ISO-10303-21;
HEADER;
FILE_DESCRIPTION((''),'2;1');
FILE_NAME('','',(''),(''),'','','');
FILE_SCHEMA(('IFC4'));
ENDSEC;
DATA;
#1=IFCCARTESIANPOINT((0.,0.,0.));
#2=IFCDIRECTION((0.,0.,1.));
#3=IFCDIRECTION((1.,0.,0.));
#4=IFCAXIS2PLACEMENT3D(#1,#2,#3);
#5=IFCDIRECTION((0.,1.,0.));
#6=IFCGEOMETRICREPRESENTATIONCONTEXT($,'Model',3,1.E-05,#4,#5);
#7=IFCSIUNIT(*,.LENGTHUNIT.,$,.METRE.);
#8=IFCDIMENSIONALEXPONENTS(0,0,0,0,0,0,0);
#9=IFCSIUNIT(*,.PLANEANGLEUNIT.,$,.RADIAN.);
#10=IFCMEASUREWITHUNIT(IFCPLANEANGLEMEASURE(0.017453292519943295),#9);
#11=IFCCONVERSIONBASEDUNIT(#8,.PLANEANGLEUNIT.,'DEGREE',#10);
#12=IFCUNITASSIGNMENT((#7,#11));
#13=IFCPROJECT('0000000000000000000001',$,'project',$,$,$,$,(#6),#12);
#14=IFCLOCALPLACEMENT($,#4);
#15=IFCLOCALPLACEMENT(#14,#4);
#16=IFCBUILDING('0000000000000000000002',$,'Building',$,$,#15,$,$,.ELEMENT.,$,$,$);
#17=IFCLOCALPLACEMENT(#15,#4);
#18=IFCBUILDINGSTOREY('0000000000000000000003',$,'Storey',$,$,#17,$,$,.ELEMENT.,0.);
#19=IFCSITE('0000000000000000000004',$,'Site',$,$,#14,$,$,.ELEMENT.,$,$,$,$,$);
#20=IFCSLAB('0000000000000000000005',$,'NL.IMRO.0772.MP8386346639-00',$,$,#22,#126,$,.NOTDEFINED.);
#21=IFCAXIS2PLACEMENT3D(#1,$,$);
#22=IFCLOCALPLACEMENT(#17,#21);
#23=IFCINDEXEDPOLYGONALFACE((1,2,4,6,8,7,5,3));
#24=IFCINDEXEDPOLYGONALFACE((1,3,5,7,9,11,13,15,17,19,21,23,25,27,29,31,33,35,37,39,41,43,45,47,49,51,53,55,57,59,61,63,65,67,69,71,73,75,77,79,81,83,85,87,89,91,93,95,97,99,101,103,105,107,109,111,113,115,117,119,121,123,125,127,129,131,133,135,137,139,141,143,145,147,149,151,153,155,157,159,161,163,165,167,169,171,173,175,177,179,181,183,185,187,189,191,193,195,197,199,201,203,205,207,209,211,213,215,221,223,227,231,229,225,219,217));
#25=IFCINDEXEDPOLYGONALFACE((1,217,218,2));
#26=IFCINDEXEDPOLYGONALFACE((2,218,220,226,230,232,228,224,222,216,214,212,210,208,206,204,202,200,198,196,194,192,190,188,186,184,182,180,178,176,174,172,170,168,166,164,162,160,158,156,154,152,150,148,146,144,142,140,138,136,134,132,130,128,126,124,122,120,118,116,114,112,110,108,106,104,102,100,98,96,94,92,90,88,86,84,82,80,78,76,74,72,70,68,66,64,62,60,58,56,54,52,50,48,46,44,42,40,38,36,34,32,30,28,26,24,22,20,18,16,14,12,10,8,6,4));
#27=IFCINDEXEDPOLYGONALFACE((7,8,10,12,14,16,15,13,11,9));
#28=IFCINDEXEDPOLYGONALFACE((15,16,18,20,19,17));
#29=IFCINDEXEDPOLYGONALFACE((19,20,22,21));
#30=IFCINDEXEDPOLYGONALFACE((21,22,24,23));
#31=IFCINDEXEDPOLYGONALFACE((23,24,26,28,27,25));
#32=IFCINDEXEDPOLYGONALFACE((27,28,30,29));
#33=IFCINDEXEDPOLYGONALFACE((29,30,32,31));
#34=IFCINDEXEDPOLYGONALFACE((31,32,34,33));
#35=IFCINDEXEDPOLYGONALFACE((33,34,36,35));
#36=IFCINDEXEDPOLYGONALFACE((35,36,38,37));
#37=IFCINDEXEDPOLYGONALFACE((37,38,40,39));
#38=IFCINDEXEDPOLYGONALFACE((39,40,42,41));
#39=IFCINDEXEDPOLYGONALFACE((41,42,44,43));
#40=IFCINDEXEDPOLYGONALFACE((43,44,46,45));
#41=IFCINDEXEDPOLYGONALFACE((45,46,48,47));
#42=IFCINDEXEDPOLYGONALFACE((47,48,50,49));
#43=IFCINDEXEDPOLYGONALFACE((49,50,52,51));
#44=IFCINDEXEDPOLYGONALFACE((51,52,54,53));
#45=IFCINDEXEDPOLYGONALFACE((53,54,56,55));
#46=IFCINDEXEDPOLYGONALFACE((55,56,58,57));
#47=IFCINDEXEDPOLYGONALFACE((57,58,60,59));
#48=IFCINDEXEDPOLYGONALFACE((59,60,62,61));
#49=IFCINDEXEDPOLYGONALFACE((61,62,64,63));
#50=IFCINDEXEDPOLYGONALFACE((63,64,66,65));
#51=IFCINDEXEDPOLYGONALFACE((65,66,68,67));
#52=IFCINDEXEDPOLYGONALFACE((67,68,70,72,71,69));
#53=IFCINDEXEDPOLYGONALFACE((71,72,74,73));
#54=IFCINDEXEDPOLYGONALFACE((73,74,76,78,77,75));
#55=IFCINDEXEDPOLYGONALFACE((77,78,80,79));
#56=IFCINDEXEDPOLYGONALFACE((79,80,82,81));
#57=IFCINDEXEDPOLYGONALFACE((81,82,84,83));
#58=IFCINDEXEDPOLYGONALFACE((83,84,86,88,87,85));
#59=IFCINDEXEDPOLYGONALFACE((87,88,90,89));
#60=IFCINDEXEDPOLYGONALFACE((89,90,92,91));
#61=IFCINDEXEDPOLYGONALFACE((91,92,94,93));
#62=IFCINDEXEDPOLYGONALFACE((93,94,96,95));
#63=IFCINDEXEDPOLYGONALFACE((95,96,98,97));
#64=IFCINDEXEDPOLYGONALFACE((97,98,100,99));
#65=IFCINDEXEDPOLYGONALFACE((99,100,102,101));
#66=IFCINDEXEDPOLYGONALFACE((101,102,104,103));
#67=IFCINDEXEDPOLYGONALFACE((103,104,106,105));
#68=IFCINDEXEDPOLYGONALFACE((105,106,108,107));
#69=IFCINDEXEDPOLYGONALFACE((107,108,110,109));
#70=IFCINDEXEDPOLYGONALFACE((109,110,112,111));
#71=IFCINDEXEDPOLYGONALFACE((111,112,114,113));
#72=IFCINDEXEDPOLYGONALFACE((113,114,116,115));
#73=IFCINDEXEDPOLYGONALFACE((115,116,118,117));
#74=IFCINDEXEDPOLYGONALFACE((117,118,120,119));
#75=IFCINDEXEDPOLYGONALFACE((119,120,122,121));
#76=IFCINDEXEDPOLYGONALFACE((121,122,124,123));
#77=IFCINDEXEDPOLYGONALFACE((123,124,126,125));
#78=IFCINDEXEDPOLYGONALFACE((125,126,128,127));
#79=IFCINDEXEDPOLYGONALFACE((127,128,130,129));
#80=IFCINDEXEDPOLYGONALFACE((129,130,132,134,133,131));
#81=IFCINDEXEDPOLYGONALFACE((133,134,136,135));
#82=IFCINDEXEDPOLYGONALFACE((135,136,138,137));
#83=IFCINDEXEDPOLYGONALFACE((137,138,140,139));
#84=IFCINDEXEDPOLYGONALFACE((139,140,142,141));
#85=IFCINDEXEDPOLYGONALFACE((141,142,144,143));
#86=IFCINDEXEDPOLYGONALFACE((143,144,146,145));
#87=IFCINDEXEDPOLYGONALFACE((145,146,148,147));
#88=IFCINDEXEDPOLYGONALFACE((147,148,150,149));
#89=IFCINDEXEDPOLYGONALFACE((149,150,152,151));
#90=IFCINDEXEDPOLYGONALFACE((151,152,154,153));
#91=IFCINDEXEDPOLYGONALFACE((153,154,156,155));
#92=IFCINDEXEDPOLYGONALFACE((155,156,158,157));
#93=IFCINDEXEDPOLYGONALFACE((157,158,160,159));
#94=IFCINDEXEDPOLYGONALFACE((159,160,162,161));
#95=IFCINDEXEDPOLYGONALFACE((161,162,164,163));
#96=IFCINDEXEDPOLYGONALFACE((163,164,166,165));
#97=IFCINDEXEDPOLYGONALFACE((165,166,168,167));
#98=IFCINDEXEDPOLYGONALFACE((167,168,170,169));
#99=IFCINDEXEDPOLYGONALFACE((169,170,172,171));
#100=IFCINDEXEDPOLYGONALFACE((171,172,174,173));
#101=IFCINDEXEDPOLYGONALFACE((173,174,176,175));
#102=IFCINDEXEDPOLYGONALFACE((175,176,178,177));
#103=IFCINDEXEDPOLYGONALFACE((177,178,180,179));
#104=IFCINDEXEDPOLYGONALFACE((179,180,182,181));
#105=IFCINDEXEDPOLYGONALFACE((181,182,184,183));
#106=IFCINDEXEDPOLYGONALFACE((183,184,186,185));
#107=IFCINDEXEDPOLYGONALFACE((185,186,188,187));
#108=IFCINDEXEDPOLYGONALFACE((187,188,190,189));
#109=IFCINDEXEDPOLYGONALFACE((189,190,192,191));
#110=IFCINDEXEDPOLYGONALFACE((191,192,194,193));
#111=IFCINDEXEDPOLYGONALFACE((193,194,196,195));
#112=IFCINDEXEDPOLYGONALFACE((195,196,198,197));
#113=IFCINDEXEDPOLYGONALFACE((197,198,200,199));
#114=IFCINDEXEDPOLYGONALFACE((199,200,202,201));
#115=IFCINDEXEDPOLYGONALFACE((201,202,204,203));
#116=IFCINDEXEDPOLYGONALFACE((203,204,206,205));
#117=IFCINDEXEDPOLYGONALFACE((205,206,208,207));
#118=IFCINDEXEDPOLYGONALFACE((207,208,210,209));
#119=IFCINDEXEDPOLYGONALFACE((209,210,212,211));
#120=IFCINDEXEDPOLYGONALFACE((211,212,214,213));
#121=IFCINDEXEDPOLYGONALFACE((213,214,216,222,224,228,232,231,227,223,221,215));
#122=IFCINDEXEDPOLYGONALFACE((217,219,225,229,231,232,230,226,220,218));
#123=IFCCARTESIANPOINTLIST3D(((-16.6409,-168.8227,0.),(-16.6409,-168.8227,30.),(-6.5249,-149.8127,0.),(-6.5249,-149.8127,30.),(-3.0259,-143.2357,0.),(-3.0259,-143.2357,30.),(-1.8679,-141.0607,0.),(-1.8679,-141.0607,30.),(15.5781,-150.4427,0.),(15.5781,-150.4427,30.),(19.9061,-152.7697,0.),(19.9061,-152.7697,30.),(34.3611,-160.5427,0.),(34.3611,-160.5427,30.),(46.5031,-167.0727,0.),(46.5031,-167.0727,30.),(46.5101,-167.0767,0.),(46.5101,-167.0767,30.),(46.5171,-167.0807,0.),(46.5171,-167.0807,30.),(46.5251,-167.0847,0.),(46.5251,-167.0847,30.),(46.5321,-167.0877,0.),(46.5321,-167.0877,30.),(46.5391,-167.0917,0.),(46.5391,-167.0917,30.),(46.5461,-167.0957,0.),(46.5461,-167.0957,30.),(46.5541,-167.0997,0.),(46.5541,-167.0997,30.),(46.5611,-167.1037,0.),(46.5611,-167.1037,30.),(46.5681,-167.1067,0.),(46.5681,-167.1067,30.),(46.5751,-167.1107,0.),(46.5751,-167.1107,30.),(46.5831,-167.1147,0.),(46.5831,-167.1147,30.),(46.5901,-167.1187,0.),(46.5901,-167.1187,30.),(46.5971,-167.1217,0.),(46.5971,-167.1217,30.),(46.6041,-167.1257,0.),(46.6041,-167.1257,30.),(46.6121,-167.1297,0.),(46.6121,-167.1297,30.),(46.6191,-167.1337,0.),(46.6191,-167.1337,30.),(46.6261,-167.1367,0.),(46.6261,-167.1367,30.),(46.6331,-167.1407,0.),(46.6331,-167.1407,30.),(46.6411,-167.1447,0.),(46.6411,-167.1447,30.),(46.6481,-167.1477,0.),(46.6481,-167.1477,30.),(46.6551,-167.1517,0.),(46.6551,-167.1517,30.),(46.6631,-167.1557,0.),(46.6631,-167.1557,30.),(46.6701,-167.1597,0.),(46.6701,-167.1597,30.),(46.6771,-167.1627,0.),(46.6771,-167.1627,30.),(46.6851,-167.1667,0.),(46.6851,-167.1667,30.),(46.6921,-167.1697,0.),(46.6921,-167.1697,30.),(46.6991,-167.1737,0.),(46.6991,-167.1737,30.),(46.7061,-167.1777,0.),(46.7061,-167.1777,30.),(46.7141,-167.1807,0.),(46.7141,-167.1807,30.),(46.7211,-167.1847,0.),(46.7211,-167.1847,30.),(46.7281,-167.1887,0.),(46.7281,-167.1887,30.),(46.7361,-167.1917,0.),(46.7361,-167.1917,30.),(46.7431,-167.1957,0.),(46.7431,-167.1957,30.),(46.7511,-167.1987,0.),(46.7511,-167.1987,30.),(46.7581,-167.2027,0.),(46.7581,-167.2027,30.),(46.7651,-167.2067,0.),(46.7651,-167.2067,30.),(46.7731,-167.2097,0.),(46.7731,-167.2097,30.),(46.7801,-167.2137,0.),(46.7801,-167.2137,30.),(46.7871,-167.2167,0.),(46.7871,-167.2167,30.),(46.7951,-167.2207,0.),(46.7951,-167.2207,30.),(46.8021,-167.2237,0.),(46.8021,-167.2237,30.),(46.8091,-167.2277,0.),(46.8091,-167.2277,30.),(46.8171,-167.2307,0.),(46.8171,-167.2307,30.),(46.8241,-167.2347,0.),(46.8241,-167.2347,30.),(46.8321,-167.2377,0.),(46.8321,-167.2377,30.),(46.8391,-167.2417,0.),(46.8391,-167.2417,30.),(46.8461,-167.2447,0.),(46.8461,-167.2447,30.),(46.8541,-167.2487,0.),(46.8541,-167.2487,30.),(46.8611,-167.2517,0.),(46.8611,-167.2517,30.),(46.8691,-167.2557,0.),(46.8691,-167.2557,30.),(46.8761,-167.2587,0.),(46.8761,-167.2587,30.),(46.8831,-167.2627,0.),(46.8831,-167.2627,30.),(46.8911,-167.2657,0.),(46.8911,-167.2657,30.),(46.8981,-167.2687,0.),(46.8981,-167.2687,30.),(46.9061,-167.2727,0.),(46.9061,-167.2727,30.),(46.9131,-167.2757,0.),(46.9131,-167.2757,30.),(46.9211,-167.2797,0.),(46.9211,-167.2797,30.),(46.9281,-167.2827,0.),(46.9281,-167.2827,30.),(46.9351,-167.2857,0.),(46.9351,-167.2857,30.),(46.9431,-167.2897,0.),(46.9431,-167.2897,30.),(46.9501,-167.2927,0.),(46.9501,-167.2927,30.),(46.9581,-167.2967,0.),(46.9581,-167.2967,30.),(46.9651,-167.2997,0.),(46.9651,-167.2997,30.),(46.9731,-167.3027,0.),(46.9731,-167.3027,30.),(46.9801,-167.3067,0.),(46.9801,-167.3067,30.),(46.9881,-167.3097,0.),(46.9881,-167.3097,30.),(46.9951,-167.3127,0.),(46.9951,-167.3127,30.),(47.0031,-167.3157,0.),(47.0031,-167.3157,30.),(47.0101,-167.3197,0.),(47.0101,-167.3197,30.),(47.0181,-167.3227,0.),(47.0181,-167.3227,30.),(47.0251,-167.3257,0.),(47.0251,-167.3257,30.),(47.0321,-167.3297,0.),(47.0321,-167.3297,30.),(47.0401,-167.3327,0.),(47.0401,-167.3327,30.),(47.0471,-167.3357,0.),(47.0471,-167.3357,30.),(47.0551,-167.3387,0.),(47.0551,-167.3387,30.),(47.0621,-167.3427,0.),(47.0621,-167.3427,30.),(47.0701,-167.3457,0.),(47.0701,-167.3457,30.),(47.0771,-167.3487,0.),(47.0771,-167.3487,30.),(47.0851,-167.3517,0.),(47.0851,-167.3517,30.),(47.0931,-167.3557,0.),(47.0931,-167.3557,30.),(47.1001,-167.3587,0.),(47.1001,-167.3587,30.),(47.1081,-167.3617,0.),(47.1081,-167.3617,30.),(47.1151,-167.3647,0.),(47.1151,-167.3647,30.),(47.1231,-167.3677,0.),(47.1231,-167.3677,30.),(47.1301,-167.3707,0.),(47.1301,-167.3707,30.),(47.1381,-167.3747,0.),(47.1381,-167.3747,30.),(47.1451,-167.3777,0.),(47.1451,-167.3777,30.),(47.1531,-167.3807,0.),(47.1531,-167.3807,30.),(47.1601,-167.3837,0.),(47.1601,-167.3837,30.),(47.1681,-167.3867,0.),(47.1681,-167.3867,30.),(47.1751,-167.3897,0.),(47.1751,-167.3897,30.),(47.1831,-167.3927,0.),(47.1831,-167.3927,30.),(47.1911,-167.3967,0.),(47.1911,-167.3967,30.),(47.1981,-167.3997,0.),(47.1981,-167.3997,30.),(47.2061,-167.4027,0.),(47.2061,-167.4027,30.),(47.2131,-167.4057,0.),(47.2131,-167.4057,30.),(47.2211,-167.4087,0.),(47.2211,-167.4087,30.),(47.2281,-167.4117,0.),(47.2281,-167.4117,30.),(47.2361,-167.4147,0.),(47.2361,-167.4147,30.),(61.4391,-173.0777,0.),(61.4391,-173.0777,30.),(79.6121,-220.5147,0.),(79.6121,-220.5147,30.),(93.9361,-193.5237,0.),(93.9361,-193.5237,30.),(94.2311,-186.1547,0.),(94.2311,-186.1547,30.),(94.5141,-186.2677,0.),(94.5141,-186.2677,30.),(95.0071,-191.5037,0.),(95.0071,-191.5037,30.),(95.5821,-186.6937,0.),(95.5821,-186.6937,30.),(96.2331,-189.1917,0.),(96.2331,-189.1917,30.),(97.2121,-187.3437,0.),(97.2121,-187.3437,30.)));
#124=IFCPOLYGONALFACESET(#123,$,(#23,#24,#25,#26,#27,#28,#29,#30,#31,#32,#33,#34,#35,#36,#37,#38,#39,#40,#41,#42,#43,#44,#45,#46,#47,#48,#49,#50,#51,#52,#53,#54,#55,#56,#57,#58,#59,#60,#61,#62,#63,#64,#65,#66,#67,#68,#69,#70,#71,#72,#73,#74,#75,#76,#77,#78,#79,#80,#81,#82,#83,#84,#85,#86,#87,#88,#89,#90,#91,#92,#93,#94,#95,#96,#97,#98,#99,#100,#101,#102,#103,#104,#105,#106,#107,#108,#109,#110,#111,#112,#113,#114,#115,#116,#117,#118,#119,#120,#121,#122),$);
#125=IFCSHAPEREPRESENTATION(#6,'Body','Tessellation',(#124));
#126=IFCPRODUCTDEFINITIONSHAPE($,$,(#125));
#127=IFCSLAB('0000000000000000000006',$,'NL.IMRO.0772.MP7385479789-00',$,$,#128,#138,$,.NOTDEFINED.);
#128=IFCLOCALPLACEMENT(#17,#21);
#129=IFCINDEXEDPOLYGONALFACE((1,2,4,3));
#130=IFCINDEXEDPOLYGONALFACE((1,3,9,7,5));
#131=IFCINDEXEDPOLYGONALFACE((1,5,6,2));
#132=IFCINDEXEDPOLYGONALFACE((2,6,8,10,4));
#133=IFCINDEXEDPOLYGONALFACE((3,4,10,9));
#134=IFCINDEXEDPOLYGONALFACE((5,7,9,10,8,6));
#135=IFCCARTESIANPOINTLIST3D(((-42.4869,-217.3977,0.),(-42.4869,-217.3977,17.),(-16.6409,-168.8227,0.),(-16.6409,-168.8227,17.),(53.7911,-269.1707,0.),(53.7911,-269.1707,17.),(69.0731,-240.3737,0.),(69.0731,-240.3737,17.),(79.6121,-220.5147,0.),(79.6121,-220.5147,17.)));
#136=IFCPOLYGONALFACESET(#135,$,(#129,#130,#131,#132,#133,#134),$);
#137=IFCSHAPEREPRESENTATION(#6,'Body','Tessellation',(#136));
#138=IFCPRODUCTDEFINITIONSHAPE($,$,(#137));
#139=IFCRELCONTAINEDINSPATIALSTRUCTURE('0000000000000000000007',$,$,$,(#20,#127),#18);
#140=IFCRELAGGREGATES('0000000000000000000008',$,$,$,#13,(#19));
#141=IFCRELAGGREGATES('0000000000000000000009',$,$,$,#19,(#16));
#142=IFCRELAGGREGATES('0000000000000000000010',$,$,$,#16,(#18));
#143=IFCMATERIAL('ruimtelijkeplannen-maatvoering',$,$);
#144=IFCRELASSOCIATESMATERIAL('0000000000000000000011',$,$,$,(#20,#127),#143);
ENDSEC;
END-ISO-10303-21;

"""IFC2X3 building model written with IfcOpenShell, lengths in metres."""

from ifc_helpers import new_model, entity, si_unit, converted_unit, direction, origin_with_axes, place, context, project, spatial, polyline, outline, extrude, material, element, save


model = new_model("IFC2X3")

# Units and contexts
model_context = context("Model", 3, precision=1e-05, world=origin_with_axes(), true_north=direction((0.0, 1.0, 0.0)))
ifc_project = project(units=[si_unit("LENGTHUNIT", "METRE"), converted_unit("PLANEANGLEUNIT", "DEGREE", entity("IfcPlaneAngleMeasure", 0.017453292519943295), si_unit("PLANEANGLEUNIT", "RADIAN"), dimensions=[0, 0, 0, 0, 0, 0, 0])], contexts=[model_context])

# Site, building, storey
site_placement = place(None, origin_with_axes())
site = spatial("IfcSite", under=ifc_project, at=site_placement, Name="Site", CompositionType="ELEMENT")
building_placement = place(site_placement, origin_with_axes())
building = spatial("IfcBuilding", under=site, at=building_placement, Name="Building", CompositionType="ELEMENT")
storey_placement = place(building_placement, origin_with_axes())
storey = spatial("IfcBuildingStorey", under=building, at=storey_placement, Name="Storey", CompositionType="ELEMENT", Elevation=0.0)

# Slabs
ifc_material = material(Name="ruimtelijkeplannen-maatvoering")
slab_1_placement = place(storey_placement, origin_with_axes())
element("IfcSlab", 1, at=slab_1_placement, inside=storey, material=ifc_material, Name="NL.IMRO.0772.MP8386346639-00", PredefinedType="NOTDEFINED", context=model_context, shape_type="SweptSolid", body=[
    extrude(outline(polyline([(46.5101, -167.0767), (46.5171, -167.0807), (46.5251, -167.0847), (46.5321, -167.0877), (46.5391, -167.0917), (46.5461, -167.0957), (46.5541, -167.0997), (46.5611, -167.1037), (46.5681, -167.1067), (46.5751, -167.1107), (46.5831, -167.1147), (46.5901, -167.1187), (46.5971, -167.1217), (46.6041, -167.1257), (46.6121, -167.1297), (46.6191, -167.1337), (46.6261, -167.1367), (46.6331, -167.1407), (46.6411, -167.1447), (46.6481, -167.1477), (46.6551, -167.1517), (46.6631, -167.1557), (46.6701, -167.1597), (46.6771, -167.1627), (46.6851, -167.1667), (46.6921, -167.1697), (46.6991, -167.1737), (46.7061, -167.1777), (46.7141, -167.1807), (46.7211, -167.1847), (46.7281, -167.1887), (46.7361, -167.1917), (46.7431, -167.1957), (46.7511, -167.1987), (46.7581, -167.2027), (46.7651, -167.2067), (46.7731, -167.2097), (46.7801, -167.2137), (46.7871, -167.2167), (46.7951, -167.2207), (46.8021, -167.2237), (46.8091, -167.2277), (46.8171, -167.2307), (46.8241, -167.2347), (46.8321, -167.2377), (46.8391, -167.2417), (46.8461, -167.2447), (46.8541, -167.2487), (46.8611, -167.2517), (46.8691, -167.2557), (46.8761, -167.2587), (46.8831, -167.2627), (46.8911, -167.2657), (46.8981, -167.2687), (46.9061, -167.2727), (46.9131, -167.2757), (46.9211, -167.2797), (46.9281, -167.2827), (46.9351, -167.2857), (46.9431, -167.2897), (46.9501, -167.2927), (46.9581, -167.2967), (46.9651, -167.2997), (46.9731, -167.3027), (46.9801, -167.3067), (46.9881, -167.3097), (46.9951, -167.3127), (47.0031, -167.3157), (47.0101, -167.3197), (47.0181, -167.3227), (47.0251, -167.3257), (47.0321, -167.3297), (47.0401, -167.3327), (47.0471, -167.3357), (47.0551, -167.3387), (47.0621, -167.3427), (47.0701, -167.3457), (47.0771, -167.3487), (47.0851, -167.3517), (47.0931, -167.3557), (47.1001, -167.3587), (47.1081, -167.3617), (47.1151, -167.3647), (47.1231, -167.3677), (47.1301, -167.3707), (47.1381, -167.3747), (47.1451, -167.3777), (47.1531, -167.3807), (47.1601, -167.3837), (47.1681, -167.3867), (47.1751, -167.3897), (47.1831, -167.3927), (47.1911, -167.3967), (47.1981, -167.3997), (47.2061, -167.4027), (47.2131, -167.4057), (47.2211, -167.4087), (47.2281, -167.4117), (47.2361, -167.4147), (61.4391, -173.0777), (94.2311, -186.1547), (94.5141, -186.2677), (95.5821, -186.6937), (97.2121, -187.3437), (96.2331, -189.1917), (95.0071, -191.5037), (93.9361, -193.5237), (79.6121, -220.5147), (-16.6409, -168.8227), (-6.5249, -149.8127), (-3.0259, -143.2357), (-1.8679, -141.0607), (15.5781, -150.4427), (19.9061, -152.7697), (34.3611, -160.5427), (46.5031, -167.0727), (46.5101, -167.0767)])), origin_with_axes(), (0.0, 0.0, 1.0), 30.0),
])
slab_2_placement = place(storey_placement, origin_with_axes())
element("IfcSlab", 2, at=slab_2_placement, inside=storey, material=ifc_material, Name="NL.IMRO.0772.MP7385479789-00", PredefinedType="NOTDEFINED", context=model_context, shape_type="SweptSolid", body=[
    extrude(outline(polyline([(79.6121, -220.5147), (69.0731, -240.3737), (53.7911, -269.1707), (-42.4869, -217.3977), (-16.6409, -168.8227), (79.6121, -220.5147)])), origin_with_axes(), (0.0, 0.0, 1.0), 17.0),
])

save(model, "model.ifc")
